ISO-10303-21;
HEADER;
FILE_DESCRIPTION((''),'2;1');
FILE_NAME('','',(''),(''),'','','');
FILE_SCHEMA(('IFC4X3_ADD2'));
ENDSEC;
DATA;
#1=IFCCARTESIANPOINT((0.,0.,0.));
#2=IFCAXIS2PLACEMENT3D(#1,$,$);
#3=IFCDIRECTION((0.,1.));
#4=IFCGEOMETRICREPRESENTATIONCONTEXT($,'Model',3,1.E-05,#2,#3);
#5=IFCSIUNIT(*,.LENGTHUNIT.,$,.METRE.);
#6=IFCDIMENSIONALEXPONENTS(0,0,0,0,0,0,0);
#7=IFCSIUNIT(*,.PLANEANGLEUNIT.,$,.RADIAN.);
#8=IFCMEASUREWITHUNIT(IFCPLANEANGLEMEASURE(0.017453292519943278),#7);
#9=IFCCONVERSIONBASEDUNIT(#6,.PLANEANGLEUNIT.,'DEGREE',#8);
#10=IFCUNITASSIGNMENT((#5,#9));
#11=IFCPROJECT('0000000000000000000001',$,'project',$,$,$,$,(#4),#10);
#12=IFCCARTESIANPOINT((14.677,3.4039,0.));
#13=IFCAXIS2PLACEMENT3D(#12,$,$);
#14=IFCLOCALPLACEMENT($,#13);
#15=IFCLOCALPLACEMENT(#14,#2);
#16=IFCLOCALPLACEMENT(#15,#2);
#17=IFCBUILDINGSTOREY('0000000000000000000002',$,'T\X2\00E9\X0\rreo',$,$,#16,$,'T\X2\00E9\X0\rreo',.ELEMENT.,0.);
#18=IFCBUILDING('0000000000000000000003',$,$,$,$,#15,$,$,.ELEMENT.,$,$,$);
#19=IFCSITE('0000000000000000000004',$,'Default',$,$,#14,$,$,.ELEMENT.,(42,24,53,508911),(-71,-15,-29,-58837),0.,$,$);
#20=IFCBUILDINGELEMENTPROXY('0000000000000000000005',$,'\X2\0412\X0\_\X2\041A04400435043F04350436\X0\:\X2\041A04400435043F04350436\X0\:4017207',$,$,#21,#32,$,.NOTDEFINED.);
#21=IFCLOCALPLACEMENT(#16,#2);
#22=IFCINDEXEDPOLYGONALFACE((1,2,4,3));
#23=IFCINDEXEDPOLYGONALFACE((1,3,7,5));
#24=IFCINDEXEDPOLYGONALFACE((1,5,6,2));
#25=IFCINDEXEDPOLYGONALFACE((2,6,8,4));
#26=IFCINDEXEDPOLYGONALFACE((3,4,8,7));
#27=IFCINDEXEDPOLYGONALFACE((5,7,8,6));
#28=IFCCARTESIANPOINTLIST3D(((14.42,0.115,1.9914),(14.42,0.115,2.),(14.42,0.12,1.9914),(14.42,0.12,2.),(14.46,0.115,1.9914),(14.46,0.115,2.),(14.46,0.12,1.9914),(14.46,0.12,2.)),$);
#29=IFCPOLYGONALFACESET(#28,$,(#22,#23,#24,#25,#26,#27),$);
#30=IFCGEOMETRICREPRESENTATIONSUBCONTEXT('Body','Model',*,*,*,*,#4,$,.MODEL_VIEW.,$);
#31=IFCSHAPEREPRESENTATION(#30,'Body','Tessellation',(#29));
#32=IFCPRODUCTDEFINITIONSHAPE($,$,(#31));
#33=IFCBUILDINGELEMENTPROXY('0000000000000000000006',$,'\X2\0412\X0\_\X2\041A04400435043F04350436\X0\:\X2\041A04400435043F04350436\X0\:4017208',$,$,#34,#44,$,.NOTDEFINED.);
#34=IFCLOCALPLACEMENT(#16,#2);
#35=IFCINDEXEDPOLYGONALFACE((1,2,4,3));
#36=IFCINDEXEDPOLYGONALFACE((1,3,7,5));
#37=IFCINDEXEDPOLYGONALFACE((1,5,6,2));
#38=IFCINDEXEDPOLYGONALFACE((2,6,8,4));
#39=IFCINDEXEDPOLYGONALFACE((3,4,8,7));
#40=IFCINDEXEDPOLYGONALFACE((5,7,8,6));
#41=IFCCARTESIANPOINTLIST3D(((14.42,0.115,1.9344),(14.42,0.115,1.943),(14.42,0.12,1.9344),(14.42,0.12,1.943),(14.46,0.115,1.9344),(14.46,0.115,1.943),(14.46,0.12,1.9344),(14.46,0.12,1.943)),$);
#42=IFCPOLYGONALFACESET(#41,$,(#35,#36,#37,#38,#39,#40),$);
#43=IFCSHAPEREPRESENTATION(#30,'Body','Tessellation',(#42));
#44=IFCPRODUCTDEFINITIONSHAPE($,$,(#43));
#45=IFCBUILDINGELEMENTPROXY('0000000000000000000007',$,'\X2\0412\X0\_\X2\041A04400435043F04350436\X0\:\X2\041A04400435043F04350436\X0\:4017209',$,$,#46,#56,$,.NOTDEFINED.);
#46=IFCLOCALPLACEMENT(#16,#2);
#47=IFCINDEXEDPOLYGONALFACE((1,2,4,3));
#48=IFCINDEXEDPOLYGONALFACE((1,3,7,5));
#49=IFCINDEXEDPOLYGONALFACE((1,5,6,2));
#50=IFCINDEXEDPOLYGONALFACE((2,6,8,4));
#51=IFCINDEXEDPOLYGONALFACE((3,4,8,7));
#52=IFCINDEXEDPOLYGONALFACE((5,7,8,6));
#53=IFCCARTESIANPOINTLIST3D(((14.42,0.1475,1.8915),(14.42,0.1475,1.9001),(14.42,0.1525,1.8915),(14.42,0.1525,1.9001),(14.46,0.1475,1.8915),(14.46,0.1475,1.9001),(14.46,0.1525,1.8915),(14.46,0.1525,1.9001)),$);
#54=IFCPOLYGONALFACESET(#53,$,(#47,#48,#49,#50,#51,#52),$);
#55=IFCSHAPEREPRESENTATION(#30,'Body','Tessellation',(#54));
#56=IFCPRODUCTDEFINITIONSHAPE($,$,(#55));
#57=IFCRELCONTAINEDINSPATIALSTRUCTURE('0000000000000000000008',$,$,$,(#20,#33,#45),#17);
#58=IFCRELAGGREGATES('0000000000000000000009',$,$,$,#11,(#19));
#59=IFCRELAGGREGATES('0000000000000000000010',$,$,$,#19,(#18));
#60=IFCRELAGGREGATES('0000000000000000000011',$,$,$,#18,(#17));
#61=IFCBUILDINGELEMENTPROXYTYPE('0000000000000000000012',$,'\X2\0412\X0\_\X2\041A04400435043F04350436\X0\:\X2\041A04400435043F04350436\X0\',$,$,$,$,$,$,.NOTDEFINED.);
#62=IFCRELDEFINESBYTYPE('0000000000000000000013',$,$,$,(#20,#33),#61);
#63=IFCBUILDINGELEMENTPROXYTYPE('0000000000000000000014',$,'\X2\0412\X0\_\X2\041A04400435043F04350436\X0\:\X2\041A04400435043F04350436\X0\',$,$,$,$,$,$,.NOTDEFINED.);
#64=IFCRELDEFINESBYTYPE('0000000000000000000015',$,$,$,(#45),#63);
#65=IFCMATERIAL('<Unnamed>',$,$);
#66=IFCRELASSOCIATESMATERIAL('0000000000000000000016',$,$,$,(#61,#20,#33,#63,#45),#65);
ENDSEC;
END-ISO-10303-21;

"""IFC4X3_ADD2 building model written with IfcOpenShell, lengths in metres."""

from ifc_helpers import new_model, entity, si_unit, converted_unit, direction, frame, frame_2d, origin, place, context, subcontext, project, spatial, rectangle, extrude, source, transform, mapped, material, type_object, type_shapes, element, save


model = new_model("IFC4X3_ADD2")

# Units and contexts
model_context = context("Model", 3, precision=1e-05, world=origin(), true_north=direction((0.0, 1.0)))
body_context = subcontext(model_context, "Body", "Model", "MODEL_VIEW")
ifc_project = project(units=[si_unit("LENGTHUNIT", "METRE"), converted_unit("PLANEANGLEUNIT", "DEGREE", entity("IfcPlaneAngleMeasure", 0.017453292519943278), si_unit("PLANEANGLEUNIT", "RADIAN"), dimensions=[0, 0, 0, 0, 0, 0, 0])], contexts=[model_context])

# Site, building, storey
site_placement = place(None, frame((14.677, 3.4039, 0.0)))
site = spatial("IfcSite", under=ifc_project, at=site_placement, Name="Default", CompositionType="ELEMENT", RefLatitude=(42, 24, 53, 508911), RefLongitude=(-71, -15, -29, -58837), RefElevation=0.0)
building_placement = place(site_placement, origin())
building = spatial("IfcBuilding", under=site, at=building_placement, CompositionType="ELEMENT")
storey_placement = place(building_placement, origin())
storey = spatial("IfcBuildingStorey", under=building, at=storey_placement, Name="Térreo", LongName="Térreo", CompositionType="ELEMENT", Elevation=0.0)

# Building element proxies
ifc_material_1 = material(Name="<Unnamed>")
building_element_proxy_type_1 = type_object("IfcBuildingElementProxyType", Name="В_Крепеж:Крепеж", PredefinedType="NOTDEFINED", material=ifc_material_1)
shared_shape_1 = source(origin(), body_context, "Body", "SweptSolid", [
    extrude(rectangle(XDim=0.005, YDim=0.04, at=frame_2d((0.0, 0.0), x_axis=(1.0, 0.0))), frame((0.0, 0.0, -0.0043), z_axis=(0.0, 0.0, 1.0), x_axis=(0.0, 1.0, 0.0)), (0.0, 0.0, 1.0), 0.0086),
])
type_shapes(building_element_proxy_type_1, [shared_shape_1])
for number, where, name in (
    (1, (14.44, 0.1175, 1.9957), "В_Крепеж:Крепеж:4017207"),
    (2, (14.44, 0.1175, 1.9387), "В_Крепеж:Крепеж:4017208"),
):
    element("IfcBuildingElementProxy", number, at=place(storey_placement, frame(where)), inside=storey, type_object=building_element_proxy_type_1, material=ifc_material_1, Name=name, PredefinedType="NOTDEFINED", context=body_context, shape_type="MappedRepresentation", body=[
        mapped(shared_shape_1, transform((0.0, 0.0, 0.0), scale=1.0)),
    ])
building_element_proxy_type_2 = type_object("IfcBuildingElementProxyType", Name="В_Крепеж:Крепеж", PredefinedType="NOTDEFINED", material=ifc_material_1)
shared_shape_2 = source(origin(), body_context, "Body", "SweptSolid", [
    extrude(rectangle(XDim=0.04, YDim=0.005, at=frame_2d((0.0, 0.0), x_axis=(1.0, 0.0))), frame((0.0, 0.0, -0.0043), z_axis=(0.0, 0.0, 1.0), x_axis=(-1.0, 0.0, 0.0)), (0.0, 0.0, 1.0), 0.0086),
])
type_shapes(building_element_proxy_type_2, [shared_shape_2])
proxy_1_placement = place(storey_placement, frame((14.44, 0.15, 1.8958)))
element("IfcBuildingElementProxy", 3, at=proxy_1_placement, inside=storey, type_object=building_element_proxy_type_2, material=ifc_material_1, Name="В_Крепеж:Крепеж:4017209", PredefinedType="NOTDEFINED", context=body_context, shape_type="MappedRepresentation", body=[
    mapped(shared_shape_2, transform((0.0, 0.0, 0.0), scale=1.0)),
])

save(model, "model.ifc")
